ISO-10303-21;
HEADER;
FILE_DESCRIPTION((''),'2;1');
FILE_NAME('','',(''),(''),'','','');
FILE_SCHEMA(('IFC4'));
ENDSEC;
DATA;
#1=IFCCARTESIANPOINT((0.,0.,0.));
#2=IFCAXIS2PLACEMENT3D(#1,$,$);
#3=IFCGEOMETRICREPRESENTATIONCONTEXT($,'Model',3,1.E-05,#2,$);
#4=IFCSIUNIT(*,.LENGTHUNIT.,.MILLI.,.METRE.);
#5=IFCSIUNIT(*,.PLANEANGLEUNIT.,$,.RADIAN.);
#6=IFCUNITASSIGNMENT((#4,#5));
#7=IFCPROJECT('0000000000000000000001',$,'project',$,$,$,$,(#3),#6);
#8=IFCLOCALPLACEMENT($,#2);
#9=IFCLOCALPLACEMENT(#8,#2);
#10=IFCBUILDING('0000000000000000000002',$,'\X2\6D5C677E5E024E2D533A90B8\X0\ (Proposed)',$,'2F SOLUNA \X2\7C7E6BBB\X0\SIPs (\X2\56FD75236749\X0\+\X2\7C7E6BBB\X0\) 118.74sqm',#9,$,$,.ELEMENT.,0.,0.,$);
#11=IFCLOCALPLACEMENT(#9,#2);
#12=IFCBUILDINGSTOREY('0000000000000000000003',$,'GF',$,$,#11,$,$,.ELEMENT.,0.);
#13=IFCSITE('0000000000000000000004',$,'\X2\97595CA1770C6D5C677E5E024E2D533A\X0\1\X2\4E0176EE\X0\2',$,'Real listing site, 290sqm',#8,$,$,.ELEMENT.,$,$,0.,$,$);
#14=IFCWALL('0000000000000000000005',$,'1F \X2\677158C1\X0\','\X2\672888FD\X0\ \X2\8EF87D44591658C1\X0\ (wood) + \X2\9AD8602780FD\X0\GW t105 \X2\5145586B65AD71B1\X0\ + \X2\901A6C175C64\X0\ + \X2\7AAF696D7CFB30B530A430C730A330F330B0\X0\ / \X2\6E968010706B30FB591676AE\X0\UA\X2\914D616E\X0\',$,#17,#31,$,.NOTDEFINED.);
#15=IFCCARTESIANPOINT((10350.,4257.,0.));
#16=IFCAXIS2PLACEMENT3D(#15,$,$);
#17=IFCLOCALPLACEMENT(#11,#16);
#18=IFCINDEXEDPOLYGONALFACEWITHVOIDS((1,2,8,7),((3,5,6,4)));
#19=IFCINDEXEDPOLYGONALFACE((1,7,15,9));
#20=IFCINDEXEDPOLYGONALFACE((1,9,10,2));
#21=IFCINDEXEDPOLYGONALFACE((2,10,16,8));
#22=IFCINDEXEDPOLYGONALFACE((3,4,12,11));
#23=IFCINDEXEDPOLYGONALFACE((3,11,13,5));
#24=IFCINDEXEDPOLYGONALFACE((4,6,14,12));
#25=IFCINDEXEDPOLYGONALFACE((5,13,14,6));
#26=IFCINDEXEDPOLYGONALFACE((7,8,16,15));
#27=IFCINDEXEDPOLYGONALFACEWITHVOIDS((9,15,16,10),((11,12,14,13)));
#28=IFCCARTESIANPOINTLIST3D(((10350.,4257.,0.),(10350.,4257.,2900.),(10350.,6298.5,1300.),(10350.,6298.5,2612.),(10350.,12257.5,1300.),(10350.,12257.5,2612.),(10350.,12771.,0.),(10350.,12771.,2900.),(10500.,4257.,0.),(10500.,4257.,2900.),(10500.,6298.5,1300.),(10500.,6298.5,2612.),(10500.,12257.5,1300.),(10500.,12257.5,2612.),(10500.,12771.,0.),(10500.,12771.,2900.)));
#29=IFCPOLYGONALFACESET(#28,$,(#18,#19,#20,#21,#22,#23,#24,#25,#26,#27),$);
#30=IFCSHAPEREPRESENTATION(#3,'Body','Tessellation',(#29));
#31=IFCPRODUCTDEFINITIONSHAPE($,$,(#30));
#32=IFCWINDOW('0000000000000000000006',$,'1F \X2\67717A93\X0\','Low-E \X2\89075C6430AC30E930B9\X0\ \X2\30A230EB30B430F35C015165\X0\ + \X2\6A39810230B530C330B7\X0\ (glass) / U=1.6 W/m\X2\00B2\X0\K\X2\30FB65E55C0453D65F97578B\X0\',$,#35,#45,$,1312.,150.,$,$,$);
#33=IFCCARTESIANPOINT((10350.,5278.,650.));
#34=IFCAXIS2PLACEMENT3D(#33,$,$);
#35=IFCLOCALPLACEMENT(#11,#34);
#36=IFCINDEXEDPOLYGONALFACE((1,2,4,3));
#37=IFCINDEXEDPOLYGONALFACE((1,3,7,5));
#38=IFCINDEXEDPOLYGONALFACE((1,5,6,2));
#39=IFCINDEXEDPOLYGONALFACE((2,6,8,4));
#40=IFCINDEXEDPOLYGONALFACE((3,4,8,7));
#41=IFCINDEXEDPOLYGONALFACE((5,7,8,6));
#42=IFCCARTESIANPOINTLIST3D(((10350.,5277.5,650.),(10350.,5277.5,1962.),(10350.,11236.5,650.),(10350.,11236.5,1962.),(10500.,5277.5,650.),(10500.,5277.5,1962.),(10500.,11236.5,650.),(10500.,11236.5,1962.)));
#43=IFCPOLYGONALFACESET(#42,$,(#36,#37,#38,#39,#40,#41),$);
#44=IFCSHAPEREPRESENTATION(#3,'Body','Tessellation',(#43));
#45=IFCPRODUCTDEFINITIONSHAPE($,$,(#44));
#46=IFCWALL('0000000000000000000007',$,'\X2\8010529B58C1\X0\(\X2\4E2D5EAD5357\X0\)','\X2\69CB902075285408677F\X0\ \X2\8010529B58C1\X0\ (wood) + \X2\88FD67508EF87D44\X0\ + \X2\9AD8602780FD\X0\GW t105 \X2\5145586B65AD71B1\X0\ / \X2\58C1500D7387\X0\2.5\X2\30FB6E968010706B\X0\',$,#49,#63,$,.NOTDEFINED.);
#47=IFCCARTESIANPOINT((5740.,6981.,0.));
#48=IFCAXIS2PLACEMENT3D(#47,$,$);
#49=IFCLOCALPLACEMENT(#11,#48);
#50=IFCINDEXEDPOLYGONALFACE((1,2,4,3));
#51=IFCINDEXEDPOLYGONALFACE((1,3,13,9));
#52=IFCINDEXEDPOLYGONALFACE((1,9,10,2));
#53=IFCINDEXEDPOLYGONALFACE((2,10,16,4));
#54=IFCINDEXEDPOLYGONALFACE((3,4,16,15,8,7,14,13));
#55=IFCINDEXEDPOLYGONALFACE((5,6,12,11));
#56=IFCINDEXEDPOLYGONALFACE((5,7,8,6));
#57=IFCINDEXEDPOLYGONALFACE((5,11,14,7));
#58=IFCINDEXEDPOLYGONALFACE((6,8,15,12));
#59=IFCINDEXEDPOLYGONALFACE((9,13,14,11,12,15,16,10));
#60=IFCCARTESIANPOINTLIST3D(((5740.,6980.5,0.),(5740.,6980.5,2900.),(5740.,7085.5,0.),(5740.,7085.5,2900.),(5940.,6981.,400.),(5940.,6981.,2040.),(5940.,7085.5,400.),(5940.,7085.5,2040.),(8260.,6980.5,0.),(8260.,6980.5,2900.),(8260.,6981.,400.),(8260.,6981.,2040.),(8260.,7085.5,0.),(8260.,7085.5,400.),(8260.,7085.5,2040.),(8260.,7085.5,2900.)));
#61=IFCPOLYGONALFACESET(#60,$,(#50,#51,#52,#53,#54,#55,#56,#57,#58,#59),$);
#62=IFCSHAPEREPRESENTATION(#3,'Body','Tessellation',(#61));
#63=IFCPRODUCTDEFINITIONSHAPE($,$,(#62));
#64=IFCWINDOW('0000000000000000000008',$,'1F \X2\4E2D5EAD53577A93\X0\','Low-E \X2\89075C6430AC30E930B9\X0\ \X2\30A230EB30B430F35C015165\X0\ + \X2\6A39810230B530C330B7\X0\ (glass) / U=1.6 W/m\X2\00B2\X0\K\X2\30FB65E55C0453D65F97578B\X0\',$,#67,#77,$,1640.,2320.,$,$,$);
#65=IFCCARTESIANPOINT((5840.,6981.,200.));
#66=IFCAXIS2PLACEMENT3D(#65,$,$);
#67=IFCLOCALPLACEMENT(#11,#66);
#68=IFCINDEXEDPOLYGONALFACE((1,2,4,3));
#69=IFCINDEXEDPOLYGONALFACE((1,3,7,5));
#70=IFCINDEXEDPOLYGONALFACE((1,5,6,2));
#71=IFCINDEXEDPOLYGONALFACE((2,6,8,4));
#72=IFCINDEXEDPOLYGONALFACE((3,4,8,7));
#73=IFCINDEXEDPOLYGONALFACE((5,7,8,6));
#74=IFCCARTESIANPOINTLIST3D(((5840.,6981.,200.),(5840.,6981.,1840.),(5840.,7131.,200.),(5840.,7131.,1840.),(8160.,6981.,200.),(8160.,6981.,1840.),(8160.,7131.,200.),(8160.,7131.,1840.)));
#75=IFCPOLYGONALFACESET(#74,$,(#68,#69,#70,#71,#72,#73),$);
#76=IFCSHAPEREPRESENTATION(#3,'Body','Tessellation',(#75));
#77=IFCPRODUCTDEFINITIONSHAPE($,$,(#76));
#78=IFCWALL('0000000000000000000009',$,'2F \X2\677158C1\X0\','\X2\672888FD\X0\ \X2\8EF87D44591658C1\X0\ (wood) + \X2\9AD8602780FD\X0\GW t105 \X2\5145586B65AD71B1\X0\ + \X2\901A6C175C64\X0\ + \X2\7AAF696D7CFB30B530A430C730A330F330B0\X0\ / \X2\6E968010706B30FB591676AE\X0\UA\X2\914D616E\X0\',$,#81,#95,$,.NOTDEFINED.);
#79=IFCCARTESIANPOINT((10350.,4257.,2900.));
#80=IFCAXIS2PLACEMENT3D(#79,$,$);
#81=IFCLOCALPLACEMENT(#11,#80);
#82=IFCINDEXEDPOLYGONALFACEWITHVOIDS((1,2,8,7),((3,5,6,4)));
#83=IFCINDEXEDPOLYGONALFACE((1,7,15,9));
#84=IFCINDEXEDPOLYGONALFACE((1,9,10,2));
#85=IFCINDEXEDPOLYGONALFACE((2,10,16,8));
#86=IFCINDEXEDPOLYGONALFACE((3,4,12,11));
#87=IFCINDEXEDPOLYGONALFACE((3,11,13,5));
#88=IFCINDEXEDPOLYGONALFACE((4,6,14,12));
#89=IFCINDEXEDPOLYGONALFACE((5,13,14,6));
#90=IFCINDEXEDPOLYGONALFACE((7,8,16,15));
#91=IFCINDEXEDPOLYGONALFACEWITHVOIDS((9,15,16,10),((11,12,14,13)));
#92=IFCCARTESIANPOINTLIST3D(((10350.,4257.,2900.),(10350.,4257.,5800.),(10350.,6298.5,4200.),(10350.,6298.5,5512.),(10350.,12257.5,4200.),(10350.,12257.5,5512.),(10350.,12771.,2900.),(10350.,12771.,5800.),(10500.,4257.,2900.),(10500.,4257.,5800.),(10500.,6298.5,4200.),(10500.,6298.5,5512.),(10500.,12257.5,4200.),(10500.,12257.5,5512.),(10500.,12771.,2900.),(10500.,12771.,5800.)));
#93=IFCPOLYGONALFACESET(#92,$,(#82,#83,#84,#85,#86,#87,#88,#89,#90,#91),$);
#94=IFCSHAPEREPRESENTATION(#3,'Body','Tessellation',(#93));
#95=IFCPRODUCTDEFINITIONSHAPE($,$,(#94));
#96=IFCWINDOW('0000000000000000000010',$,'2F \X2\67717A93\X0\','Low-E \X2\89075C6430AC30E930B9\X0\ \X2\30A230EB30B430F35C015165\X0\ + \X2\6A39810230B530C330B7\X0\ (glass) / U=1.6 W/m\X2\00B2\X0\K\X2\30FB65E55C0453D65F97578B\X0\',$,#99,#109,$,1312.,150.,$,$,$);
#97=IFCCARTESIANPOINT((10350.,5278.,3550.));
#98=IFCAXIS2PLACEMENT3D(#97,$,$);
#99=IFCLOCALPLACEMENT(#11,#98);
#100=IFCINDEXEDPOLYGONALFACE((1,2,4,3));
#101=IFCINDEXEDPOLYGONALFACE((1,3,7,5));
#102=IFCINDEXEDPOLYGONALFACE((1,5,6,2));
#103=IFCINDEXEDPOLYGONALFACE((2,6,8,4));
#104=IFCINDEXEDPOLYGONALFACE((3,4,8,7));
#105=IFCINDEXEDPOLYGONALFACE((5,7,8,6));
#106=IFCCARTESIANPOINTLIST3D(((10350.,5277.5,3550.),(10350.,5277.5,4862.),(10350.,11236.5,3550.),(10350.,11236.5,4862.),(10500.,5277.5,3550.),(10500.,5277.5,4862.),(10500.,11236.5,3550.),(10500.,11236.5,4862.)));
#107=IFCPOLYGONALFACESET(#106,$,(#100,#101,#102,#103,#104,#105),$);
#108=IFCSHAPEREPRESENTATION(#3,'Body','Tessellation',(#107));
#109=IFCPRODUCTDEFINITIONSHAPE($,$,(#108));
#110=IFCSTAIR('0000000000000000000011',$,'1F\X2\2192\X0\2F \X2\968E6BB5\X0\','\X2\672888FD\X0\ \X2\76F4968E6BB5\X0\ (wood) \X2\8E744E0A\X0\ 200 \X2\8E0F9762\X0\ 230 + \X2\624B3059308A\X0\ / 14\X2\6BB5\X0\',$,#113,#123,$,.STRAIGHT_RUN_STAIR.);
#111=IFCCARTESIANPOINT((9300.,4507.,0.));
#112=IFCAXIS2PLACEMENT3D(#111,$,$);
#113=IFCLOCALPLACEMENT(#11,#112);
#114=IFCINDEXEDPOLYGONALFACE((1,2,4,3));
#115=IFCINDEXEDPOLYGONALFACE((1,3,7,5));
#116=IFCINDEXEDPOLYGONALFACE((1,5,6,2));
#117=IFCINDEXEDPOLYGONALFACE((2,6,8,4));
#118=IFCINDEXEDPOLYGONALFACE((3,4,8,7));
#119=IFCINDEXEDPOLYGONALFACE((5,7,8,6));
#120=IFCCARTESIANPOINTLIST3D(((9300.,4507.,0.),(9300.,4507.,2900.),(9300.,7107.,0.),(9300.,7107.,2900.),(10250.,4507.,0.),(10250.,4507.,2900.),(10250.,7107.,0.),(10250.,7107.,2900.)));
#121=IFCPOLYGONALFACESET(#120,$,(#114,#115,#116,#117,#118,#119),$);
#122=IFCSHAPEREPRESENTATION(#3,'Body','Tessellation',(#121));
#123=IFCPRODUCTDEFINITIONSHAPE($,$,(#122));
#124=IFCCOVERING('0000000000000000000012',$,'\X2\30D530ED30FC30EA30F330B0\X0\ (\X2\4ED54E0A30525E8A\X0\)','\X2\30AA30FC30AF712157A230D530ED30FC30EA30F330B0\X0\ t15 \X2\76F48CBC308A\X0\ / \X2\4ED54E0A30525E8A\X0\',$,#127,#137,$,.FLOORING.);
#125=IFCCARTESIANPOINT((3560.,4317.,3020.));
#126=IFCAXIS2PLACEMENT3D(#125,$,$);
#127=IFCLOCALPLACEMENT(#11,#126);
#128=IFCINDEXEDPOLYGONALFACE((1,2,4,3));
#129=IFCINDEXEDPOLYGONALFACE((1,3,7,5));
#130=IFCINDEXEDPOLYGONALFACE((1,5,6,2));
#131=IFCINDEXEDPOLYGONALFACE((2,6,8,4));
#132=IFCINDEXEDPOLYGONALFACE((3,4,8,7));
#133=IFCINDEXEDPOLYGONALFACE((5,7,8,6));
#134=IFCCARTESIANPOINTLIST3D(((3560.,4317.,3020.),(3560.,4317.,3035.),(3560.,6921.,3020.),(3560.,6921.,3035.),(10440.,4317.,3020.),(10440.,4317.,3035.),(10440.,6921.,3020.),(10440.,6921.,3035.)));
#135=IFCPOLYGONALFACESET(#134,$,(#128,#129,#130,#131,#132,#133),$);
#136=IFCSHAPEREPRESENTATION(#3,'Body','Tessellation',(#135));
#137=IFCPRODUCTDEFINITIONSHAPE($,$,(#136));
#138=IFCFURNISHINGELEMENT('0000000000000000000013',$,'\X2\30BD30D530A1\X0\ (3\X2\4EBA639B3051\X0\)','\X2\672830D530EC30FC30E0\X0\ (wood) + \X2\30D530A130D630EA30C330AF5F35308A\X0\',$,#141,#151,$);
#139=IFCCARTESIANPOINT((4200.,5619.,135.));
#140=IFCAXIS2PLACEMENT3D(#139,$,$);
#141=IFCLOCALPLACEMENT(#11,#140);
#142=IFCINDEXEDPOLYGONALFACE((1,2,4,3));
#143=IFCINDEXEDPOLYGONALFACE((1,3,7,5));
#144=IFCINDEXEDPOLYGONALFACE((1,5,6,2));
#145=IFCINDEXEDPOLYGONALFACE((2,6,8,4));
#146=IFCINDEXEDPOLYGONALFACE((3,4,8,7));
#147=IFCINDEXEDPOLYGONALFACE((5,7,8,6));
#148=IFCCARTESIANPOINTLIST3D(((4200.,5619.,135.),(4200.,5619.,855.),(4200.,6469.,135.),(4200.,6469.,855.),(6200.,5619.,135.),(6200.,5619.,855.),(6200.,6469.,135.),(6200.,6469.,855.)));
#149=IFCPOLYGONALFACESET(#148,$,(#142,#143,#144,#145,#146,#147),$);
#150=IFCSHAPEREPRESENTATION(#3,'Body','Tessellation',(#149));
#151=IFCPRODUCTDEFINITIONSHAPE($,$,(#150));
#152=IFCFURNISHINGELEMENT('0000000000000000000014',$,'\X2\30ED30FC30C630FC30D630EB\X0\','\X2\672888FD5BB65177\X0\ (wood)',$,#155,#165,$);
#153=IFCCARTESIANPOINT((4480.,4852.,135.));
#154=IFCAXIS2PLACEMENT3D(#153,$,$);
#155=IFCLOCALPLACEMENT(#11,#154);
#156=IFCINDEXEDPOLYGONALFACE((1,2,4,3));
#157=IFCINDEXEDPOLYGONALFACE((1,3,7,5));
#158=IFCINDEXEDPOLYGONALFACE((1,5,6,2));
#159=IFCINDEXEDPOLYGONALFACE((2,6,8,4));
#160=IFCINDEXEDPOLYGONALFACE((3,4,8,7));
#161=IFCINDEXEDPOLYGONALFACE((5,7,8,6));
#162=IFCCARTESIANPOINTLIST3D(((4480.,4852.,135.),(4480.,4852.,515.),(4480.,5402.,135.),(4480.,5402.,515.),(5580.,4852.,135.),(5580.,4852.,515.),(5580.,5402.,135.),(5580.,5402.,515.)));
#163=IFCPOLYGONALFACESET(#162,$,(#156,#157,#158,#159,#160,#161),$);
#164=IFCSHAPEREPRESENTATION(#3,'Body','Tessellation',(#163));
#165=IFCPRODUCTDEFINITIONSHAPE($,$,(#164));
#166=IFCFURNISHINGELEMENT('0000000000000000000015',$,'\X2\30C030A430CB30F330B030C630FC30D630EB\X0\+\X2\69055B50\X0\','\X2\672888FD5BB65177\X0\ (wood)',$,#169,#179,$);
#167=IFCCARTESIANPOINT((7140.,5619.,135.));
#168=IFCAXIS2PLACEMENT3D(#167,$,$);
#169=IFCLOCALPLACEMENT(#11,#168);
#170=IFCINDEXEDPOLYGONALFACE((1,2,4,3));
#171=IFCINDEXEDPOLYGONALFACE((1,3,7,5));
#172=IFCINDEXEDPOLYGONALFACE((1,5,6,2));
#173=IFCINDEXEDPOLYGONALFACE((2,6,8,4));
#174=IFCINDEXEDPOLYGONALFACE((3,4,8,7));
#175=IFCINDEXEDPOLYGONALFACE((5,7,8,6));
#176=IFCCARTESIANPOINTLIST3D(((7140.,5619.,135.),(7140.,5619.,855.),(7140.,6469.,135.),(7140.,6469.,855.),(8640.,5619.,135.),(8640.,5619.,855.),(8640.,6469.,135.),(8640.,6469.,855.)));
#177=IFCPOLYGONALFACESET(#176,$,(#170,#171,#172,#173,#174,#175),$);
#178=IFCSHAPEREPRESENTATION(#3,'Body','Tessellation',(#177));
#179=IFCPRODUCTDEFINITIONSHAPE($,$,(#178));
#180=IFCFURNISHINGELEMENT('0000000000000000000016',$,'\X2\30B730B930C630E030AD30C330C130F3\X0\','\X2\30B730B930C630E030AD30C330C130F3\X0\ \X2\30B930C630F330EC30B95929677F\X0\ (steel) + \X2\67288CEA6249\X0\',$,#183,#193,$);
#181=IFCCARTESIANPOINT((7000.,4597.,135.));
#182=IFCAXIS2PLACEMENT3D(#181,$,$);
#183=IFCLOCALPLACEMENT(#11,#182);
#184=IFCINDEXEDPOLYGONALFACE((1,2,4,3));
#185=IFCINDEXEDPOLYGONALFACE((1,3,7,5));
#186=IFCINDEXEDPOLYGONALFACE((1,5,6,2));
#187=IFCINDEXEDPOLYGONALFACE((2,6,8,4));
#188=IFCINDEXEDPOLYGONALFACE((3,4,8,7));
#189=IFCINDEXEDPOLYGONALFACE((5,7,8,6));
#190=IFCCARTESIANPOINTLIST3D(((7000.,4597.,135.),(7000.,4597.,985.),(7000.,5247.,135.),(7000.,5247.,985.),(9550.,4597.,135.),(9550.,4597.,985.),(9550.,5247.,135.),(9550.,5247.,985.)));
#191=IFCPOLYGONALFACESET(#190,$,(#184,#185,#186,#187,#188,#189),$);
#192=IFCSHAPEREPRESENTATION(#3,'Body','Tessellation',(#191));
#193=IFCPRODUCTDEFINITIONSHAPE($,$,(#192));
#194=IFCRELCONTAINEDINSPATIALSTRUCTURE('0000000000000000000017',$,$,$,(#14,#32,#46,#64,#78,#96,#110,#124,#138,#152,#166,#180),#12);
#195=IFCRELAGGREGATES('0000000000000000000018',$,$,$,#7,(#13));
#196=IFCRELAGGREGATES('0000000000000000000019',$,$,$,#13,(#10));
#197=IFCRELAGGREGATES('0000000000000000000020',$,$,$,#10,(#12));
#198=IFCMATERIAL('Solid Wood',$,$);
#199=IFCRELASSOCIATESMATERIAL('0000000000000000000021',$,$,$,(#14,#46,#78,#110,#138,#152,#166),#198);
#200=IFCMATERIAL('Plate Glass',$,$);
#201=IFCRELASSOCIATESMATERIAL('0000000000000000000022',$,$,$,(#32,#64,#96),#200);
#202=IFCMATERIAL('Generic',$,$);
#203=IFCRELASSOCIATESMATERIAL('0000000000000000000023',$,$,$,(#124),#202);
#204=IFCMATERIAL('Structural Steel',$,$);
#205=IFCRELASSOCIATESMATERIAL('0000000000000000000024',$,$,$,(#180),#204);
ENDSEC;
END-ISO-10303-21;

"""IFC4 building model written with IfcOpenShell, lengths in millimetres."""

from ifc_helpers import new_model, si_unit, frame, frame_2d, origin, place, context, project, spatial, rectangle, extrude, material, element, fill, save


model = new_model("IFC4")

# Units and contexts
model_context = context("Model", 3, precision=1e-05, world=origin())
ifc_project = project(units=[si_unit("LENGTHUNIT", "METRE", prefix="MILLI"), si_unit("PLANEANGLEUNIT", "RADIAN")], contexts=[model_context])

# Site, building, storey
site_placement = place(None, origin())
site = spatial("IfcSite", under=ifc_project, at=site_placement, Name="静岡県浜松市中区1丁目2", ObjectType="Real listing site, 290sqm", CompositionType="ELEMENT", RefElevation=0.0)
building_placement = place(site_placement, origin())
building = spatial("IfcBuilding", under=site, at=building_placement, Name="浜松市中区邸 (Proposed)", ObjectType="2F SOLUNA 籾殻SIPs (国産杉+籾殻) 118.74sqm", CompositionType="ELEMENT", ElevationOfRefHeight=0.0, ElevationOfTerrain=0.0)
storey_placement = place(building_placement, origin())
storey = spatial("IfcBuildingStorey", under=building, at=storey_placement, Name="GF", CompositionType="ELEMENT", Elevation=0.0)

# Shared definitions
ifc_material_1 = material(Name="Solid Wood")

# Walls, openings, windows
wall_1_placement = place(storey_placement, frame((10350.0, 4257.0, 0.0)))
wall_1 = element("IfcWall", 1, at=wall_1_placement, inside=storey, material=ifc_material_1, Name="1F 東壁", Description="木製 軸組外壁 (wood) + 高性能GW t105 充填断熱 + 通気層 + 窯業系サイディング / 準耐火・外皮UA配慮", PredefinedType="NOTDEFINED", context=model_context, shape_type="SweptSolid", body=[
    extrude(rectangle(XDim=150.0, YDim=8514.0, at=frame_2d((75.0, 4257.0))), frame((10350.0, 4257.0, 0.0)), (0.0, 0.0, 1.0), 2900.0),
])
opening_1_placement = place(storey_placement, frame((10350.0, 5278.0, 650.0)))
opening_1 = element("IfcOpeningElement", 2, at=opening_1_placement, cuts=wall_1, PredefinedType="NOTDEFINED", context=model_context, shape_type="SweptSolid", body=[
    extrude(rectangle(XDim=150.0, YDim=5959.0, at=frame_2d((75.0, 2979.0))), frame((10350.0, 5278.0, 650.0)), (0.0, 0.0, 1.0), 1312.0),
])
ifc_material_2 = material(Name="Plate Glass")
window_1_placement = place(storey_placement, frame((10350.0, 5278.0, 650.0)))
window_1 = element("IfcWindow", 3, at=window_1_placement, inside=storey, material=ifc_material_2, Name="1F 東窓", Description="Low-E 複層ガラス アルゴン封入 + 樹脂サッシ (glass) / U=1.6 W/m²K・日射取得型", OverallHeight=1312.0, OverallWidth=150.0, context=model_context, shape_type="SweptSolid", body=[
    extrude(rectangle(XDim=150.0, YDim=5959.0, at=frame_2d((75.0, 2979.0))), frame((10350.0, 5278.0, 650.0)), (0.0, 0.0, 1.0), 1312.0),
])
fill(opening_1, window_1)
wall_2_placement = place(storey_placement, frame((5740.0, 6981.0, 0.0)))
wall_2 = element("IfcWall", 4, at=wall_2_placement, inside=storey, material=ifc_material_1, Name="耐力壁(中庭南)", Description="構造用合板 耐力壁 (wood) + 製材軸組 + 高性能GW t105 充填断熱 / 壁倍率2.5・準耐火", PredefinedType="NOTDEFINED", context=model_context, shape_type="SweptSolid", body=[
    extrude(rectangle(XDim=2520.0, YDim=105.0, at=frame_2d((1260.0, 52.0))), frame((5740.0, 6981.0, 0.0)), (0.0, 0.0, 1.0), 2900.0),
])
opening_2_placement = place(storey_placement, frame((5840.0, 6981.0, 200.0)))
opening_2 = element("IfcOpeningElement", 5, at=opening_2_placement, cuts=wall_2, PredefinedType="NOTDEFINED", context=model_context, shape_type="SweptSolid", body=[
    extrude(rectangle(XDim=2320.0, YDim=150.0, at=frame_2d((1160.0, 75.0))), frame((5840.0, 6981.0, 200.0)), (0.0, 0.0, 1.0), 1640.0),
])
window_2_placement = place(storey_placement, frame((5840.0, 6981.0, 200.0)))
window_2 = element("IfcWindow", 6, at=window_2_placement, inside=storey, material=ifc_material_2, Name="1F 中庭南窓", Description="Low-E 複層ガラス アルゴン封入 + 樹脂サッシ (glass) / U=1.6 W/m²K・日射取得型", OverallHeight=1640.0, OverallWidth=2320.0, context=model_context, shape_type="SweptSolid", body=[
    extrude(rectangle(XDim=2320.0, YDim=150.0, at=frame_2d((1160.0, 75.0))), frame((5840.0, 6981.0, 200.0)), (0.0, 0.0, 1.0), 1640.0),
])
fill(opening_2, window_2)

# Wall, opening, window
wall_3_placement = place(storey_placement, frame((10350.0, 4257.0, 2900.0)))
wall_3 = element("IfcWall", 7, at=wall_3_placement, inside=storey, material=ifc_material_1, Name="2F 東壁", Description="木製 軸組外壁 (wood) + 高性能GW t105 充填断熱 + 通気層 + 窯業系サイディング / 準耐火・外皮UA配慮", PredefinedType="NOTDEFINED", context=model_context, shape_type="SweptSolid", body=[
    extrude(rectangle(XDim=150.0, YDim=8514.0, at=frame_2d((75.0, 4257.0))), frame((10350.0, 4257.0, 2900.0)), (0.0, 0.0, 1.0), 2900.0),
])
opening_3_placement = place(storey_placement, frame((10350.0, 5278.0, 3550.0)))
opening_3 = element("IfcOpeningElement", 8, at=opening_3_placement, cuts=wall_3, PredefinedType="NOTDEFINED", context=model_context, shape_type="SweptSolid", body=[
    extrude(rectangle(XDim=150.0, YDim=5959.0, at=frame_2d((75.0, 2979.0))), frame((10350.0, 5278.0, 3550.0)), (0.0, 0.0, 1.0), 1312.0),
])
window_3_placement = place(storey_placement, frame((10350.0, 5278.0, 3550.0)))
window_3 = element("IfcWindow", 9, at=window_3_placement, inside=storey, material=ifc_material_2, Name="2F 東窓", Description="Low-E 複層ガラス アルゴン封入 + 樹脂サッシ (glass) / U=1.6 W/m²K・日射取得型", OverallHeight=1312.0, OverallWidth=150.0, context=model_context, shape_type="SweptSolid", body=[
    extrude(rectangle(XDim=150.0, YDim=5959.0, at=frame_2d((75.0, 2979.0))), frame((10350.0, 5278.0, 3550.0)), (0.0, 0.0, 1.0), 1312.0),
])
fill(opening_3, window_3)

# Stair
stair_placement = place(storey_placement, frame((9300.0, 4507.0, 0.0)))
element("IfcStair", 10, at=stair_placement, inside=storey, material=ifc_material_1, Name="1F→2F 階段", Description="木製 直階段 (wood) 蹴上 200 踏面 230 + 手すり / 14段", PredefinedType="STRAIGHT_RUN_STAIR", context=model_context, shape_type="SweptSolid", body=[
    extrude(rectangle(XDim=950.0, YDim=2600.0, at=frame_2d((475.0, 1300.0))), frame((9300.0, 4507.0, 0.0)), (0.0, 0.0, 1.0), 2900.0),
])

# Covering
ifc_material_3 = material(Name="Generic")
covering_placement = place(storey_placement, frame((3560.0, 4317.0, 3020.0)))
element("IfcCovering", 11, at=covering_placement, inside=storey, material=ifc_material_3, Name="フローリング (仕上げ床)", Description="オーク無垢フローリング t15 直貼り / 仕上げ床", PredefinedType="FLOORING", context=model_context, shape_type="SweptSolid", body=[
    extrude(rectangle(XDim=6880.0, YDim=2604.0, at=frame_2d((3440.0, 1302.0))), frame((3560.0, 4317.0, 3020.0)), (0.0, 0.0, 1.0), 15.0),
])

# Furnishing elements
furnishing_1_placement = place(storey_placement, frame((4200.0, 5619.0, 135.0)))
element("IfcFurnishingElement", 12, at=furnishing_1_placement, inside=storey, material=ifc_material_1, Name="ソファ (3人掛け)", Description="木フレーム (wood) + ファブリック張り", context=model_context, shape_type="SweptSolid", body=[
    extrude(rectangle(XDim=2000.0, YDim=850.0, at=frame_2d((1000.0, 425.0))), frame((4200.0, 5619.0, 135.0)), (0.0, 0.0, 1.0), 720.0),
])
furnishing_2_placement = place(storey_placement, frame((4480.0, 4852.0, 135.0)))
element("IfcFurnishingElement", 13, at=furnishing_2_placement, inside=storey, material=ifc_material_1, Name="ローテーブル", Description="木製家具 (wood)", context=model_context, shape_type="SweptSolid", body=[
    extrude(rectangle(XDim=1100.0, YDim=550.0, at=frame_2d((550.0, 275.0))), frame((4480.0, 4852.0, 135.0)), (0.0, 0.0, 1.0), 380.0),
])
furnishing_3_placement = place(storey_placement, frame((7140.0, 5619.0, 135.0)))
element("IfcFurnishingElement", 14, at=furnishing_3_placement, inside=storey, material=ifc_material_1, Name="ダイニングテーブル+椅子", Description="木製家具 (wood)", context=model_context, shape_type="SweptSolid", body=[
    extrude(rectangle(XDim=1500.0, YDim=850.0, at=frame_2d((750.0, 425.0))), frame((7140.0, 5619.0, 135.0)), (0.0, 0.0, 1.0), 720.0),
])
ifc_material_4 = material(Name="Structural Steel")
furnishing_4_placement = place(storey_placement, frame((7000.0, 4597.0, 135.0)))
element("IfcFurnishingElement", 15, at=furnishing_4_placement, inside=storey, material=ifc_material_4, Name="システムキッチン", Description="システムキッチン ステンレス天板 (steel) + 木質扉", context=model_context, shape_type="SweptSolid", body=[
    extrude(rectangle(XDim=2550.0, YDim=650.0, at=frame_2d((1275.0, 325.0))), frame((7000.0, 4597.0, 135.0)), (0.0, 0.0, 1.0), 850.0),
])

save(model, "model.ifc")
